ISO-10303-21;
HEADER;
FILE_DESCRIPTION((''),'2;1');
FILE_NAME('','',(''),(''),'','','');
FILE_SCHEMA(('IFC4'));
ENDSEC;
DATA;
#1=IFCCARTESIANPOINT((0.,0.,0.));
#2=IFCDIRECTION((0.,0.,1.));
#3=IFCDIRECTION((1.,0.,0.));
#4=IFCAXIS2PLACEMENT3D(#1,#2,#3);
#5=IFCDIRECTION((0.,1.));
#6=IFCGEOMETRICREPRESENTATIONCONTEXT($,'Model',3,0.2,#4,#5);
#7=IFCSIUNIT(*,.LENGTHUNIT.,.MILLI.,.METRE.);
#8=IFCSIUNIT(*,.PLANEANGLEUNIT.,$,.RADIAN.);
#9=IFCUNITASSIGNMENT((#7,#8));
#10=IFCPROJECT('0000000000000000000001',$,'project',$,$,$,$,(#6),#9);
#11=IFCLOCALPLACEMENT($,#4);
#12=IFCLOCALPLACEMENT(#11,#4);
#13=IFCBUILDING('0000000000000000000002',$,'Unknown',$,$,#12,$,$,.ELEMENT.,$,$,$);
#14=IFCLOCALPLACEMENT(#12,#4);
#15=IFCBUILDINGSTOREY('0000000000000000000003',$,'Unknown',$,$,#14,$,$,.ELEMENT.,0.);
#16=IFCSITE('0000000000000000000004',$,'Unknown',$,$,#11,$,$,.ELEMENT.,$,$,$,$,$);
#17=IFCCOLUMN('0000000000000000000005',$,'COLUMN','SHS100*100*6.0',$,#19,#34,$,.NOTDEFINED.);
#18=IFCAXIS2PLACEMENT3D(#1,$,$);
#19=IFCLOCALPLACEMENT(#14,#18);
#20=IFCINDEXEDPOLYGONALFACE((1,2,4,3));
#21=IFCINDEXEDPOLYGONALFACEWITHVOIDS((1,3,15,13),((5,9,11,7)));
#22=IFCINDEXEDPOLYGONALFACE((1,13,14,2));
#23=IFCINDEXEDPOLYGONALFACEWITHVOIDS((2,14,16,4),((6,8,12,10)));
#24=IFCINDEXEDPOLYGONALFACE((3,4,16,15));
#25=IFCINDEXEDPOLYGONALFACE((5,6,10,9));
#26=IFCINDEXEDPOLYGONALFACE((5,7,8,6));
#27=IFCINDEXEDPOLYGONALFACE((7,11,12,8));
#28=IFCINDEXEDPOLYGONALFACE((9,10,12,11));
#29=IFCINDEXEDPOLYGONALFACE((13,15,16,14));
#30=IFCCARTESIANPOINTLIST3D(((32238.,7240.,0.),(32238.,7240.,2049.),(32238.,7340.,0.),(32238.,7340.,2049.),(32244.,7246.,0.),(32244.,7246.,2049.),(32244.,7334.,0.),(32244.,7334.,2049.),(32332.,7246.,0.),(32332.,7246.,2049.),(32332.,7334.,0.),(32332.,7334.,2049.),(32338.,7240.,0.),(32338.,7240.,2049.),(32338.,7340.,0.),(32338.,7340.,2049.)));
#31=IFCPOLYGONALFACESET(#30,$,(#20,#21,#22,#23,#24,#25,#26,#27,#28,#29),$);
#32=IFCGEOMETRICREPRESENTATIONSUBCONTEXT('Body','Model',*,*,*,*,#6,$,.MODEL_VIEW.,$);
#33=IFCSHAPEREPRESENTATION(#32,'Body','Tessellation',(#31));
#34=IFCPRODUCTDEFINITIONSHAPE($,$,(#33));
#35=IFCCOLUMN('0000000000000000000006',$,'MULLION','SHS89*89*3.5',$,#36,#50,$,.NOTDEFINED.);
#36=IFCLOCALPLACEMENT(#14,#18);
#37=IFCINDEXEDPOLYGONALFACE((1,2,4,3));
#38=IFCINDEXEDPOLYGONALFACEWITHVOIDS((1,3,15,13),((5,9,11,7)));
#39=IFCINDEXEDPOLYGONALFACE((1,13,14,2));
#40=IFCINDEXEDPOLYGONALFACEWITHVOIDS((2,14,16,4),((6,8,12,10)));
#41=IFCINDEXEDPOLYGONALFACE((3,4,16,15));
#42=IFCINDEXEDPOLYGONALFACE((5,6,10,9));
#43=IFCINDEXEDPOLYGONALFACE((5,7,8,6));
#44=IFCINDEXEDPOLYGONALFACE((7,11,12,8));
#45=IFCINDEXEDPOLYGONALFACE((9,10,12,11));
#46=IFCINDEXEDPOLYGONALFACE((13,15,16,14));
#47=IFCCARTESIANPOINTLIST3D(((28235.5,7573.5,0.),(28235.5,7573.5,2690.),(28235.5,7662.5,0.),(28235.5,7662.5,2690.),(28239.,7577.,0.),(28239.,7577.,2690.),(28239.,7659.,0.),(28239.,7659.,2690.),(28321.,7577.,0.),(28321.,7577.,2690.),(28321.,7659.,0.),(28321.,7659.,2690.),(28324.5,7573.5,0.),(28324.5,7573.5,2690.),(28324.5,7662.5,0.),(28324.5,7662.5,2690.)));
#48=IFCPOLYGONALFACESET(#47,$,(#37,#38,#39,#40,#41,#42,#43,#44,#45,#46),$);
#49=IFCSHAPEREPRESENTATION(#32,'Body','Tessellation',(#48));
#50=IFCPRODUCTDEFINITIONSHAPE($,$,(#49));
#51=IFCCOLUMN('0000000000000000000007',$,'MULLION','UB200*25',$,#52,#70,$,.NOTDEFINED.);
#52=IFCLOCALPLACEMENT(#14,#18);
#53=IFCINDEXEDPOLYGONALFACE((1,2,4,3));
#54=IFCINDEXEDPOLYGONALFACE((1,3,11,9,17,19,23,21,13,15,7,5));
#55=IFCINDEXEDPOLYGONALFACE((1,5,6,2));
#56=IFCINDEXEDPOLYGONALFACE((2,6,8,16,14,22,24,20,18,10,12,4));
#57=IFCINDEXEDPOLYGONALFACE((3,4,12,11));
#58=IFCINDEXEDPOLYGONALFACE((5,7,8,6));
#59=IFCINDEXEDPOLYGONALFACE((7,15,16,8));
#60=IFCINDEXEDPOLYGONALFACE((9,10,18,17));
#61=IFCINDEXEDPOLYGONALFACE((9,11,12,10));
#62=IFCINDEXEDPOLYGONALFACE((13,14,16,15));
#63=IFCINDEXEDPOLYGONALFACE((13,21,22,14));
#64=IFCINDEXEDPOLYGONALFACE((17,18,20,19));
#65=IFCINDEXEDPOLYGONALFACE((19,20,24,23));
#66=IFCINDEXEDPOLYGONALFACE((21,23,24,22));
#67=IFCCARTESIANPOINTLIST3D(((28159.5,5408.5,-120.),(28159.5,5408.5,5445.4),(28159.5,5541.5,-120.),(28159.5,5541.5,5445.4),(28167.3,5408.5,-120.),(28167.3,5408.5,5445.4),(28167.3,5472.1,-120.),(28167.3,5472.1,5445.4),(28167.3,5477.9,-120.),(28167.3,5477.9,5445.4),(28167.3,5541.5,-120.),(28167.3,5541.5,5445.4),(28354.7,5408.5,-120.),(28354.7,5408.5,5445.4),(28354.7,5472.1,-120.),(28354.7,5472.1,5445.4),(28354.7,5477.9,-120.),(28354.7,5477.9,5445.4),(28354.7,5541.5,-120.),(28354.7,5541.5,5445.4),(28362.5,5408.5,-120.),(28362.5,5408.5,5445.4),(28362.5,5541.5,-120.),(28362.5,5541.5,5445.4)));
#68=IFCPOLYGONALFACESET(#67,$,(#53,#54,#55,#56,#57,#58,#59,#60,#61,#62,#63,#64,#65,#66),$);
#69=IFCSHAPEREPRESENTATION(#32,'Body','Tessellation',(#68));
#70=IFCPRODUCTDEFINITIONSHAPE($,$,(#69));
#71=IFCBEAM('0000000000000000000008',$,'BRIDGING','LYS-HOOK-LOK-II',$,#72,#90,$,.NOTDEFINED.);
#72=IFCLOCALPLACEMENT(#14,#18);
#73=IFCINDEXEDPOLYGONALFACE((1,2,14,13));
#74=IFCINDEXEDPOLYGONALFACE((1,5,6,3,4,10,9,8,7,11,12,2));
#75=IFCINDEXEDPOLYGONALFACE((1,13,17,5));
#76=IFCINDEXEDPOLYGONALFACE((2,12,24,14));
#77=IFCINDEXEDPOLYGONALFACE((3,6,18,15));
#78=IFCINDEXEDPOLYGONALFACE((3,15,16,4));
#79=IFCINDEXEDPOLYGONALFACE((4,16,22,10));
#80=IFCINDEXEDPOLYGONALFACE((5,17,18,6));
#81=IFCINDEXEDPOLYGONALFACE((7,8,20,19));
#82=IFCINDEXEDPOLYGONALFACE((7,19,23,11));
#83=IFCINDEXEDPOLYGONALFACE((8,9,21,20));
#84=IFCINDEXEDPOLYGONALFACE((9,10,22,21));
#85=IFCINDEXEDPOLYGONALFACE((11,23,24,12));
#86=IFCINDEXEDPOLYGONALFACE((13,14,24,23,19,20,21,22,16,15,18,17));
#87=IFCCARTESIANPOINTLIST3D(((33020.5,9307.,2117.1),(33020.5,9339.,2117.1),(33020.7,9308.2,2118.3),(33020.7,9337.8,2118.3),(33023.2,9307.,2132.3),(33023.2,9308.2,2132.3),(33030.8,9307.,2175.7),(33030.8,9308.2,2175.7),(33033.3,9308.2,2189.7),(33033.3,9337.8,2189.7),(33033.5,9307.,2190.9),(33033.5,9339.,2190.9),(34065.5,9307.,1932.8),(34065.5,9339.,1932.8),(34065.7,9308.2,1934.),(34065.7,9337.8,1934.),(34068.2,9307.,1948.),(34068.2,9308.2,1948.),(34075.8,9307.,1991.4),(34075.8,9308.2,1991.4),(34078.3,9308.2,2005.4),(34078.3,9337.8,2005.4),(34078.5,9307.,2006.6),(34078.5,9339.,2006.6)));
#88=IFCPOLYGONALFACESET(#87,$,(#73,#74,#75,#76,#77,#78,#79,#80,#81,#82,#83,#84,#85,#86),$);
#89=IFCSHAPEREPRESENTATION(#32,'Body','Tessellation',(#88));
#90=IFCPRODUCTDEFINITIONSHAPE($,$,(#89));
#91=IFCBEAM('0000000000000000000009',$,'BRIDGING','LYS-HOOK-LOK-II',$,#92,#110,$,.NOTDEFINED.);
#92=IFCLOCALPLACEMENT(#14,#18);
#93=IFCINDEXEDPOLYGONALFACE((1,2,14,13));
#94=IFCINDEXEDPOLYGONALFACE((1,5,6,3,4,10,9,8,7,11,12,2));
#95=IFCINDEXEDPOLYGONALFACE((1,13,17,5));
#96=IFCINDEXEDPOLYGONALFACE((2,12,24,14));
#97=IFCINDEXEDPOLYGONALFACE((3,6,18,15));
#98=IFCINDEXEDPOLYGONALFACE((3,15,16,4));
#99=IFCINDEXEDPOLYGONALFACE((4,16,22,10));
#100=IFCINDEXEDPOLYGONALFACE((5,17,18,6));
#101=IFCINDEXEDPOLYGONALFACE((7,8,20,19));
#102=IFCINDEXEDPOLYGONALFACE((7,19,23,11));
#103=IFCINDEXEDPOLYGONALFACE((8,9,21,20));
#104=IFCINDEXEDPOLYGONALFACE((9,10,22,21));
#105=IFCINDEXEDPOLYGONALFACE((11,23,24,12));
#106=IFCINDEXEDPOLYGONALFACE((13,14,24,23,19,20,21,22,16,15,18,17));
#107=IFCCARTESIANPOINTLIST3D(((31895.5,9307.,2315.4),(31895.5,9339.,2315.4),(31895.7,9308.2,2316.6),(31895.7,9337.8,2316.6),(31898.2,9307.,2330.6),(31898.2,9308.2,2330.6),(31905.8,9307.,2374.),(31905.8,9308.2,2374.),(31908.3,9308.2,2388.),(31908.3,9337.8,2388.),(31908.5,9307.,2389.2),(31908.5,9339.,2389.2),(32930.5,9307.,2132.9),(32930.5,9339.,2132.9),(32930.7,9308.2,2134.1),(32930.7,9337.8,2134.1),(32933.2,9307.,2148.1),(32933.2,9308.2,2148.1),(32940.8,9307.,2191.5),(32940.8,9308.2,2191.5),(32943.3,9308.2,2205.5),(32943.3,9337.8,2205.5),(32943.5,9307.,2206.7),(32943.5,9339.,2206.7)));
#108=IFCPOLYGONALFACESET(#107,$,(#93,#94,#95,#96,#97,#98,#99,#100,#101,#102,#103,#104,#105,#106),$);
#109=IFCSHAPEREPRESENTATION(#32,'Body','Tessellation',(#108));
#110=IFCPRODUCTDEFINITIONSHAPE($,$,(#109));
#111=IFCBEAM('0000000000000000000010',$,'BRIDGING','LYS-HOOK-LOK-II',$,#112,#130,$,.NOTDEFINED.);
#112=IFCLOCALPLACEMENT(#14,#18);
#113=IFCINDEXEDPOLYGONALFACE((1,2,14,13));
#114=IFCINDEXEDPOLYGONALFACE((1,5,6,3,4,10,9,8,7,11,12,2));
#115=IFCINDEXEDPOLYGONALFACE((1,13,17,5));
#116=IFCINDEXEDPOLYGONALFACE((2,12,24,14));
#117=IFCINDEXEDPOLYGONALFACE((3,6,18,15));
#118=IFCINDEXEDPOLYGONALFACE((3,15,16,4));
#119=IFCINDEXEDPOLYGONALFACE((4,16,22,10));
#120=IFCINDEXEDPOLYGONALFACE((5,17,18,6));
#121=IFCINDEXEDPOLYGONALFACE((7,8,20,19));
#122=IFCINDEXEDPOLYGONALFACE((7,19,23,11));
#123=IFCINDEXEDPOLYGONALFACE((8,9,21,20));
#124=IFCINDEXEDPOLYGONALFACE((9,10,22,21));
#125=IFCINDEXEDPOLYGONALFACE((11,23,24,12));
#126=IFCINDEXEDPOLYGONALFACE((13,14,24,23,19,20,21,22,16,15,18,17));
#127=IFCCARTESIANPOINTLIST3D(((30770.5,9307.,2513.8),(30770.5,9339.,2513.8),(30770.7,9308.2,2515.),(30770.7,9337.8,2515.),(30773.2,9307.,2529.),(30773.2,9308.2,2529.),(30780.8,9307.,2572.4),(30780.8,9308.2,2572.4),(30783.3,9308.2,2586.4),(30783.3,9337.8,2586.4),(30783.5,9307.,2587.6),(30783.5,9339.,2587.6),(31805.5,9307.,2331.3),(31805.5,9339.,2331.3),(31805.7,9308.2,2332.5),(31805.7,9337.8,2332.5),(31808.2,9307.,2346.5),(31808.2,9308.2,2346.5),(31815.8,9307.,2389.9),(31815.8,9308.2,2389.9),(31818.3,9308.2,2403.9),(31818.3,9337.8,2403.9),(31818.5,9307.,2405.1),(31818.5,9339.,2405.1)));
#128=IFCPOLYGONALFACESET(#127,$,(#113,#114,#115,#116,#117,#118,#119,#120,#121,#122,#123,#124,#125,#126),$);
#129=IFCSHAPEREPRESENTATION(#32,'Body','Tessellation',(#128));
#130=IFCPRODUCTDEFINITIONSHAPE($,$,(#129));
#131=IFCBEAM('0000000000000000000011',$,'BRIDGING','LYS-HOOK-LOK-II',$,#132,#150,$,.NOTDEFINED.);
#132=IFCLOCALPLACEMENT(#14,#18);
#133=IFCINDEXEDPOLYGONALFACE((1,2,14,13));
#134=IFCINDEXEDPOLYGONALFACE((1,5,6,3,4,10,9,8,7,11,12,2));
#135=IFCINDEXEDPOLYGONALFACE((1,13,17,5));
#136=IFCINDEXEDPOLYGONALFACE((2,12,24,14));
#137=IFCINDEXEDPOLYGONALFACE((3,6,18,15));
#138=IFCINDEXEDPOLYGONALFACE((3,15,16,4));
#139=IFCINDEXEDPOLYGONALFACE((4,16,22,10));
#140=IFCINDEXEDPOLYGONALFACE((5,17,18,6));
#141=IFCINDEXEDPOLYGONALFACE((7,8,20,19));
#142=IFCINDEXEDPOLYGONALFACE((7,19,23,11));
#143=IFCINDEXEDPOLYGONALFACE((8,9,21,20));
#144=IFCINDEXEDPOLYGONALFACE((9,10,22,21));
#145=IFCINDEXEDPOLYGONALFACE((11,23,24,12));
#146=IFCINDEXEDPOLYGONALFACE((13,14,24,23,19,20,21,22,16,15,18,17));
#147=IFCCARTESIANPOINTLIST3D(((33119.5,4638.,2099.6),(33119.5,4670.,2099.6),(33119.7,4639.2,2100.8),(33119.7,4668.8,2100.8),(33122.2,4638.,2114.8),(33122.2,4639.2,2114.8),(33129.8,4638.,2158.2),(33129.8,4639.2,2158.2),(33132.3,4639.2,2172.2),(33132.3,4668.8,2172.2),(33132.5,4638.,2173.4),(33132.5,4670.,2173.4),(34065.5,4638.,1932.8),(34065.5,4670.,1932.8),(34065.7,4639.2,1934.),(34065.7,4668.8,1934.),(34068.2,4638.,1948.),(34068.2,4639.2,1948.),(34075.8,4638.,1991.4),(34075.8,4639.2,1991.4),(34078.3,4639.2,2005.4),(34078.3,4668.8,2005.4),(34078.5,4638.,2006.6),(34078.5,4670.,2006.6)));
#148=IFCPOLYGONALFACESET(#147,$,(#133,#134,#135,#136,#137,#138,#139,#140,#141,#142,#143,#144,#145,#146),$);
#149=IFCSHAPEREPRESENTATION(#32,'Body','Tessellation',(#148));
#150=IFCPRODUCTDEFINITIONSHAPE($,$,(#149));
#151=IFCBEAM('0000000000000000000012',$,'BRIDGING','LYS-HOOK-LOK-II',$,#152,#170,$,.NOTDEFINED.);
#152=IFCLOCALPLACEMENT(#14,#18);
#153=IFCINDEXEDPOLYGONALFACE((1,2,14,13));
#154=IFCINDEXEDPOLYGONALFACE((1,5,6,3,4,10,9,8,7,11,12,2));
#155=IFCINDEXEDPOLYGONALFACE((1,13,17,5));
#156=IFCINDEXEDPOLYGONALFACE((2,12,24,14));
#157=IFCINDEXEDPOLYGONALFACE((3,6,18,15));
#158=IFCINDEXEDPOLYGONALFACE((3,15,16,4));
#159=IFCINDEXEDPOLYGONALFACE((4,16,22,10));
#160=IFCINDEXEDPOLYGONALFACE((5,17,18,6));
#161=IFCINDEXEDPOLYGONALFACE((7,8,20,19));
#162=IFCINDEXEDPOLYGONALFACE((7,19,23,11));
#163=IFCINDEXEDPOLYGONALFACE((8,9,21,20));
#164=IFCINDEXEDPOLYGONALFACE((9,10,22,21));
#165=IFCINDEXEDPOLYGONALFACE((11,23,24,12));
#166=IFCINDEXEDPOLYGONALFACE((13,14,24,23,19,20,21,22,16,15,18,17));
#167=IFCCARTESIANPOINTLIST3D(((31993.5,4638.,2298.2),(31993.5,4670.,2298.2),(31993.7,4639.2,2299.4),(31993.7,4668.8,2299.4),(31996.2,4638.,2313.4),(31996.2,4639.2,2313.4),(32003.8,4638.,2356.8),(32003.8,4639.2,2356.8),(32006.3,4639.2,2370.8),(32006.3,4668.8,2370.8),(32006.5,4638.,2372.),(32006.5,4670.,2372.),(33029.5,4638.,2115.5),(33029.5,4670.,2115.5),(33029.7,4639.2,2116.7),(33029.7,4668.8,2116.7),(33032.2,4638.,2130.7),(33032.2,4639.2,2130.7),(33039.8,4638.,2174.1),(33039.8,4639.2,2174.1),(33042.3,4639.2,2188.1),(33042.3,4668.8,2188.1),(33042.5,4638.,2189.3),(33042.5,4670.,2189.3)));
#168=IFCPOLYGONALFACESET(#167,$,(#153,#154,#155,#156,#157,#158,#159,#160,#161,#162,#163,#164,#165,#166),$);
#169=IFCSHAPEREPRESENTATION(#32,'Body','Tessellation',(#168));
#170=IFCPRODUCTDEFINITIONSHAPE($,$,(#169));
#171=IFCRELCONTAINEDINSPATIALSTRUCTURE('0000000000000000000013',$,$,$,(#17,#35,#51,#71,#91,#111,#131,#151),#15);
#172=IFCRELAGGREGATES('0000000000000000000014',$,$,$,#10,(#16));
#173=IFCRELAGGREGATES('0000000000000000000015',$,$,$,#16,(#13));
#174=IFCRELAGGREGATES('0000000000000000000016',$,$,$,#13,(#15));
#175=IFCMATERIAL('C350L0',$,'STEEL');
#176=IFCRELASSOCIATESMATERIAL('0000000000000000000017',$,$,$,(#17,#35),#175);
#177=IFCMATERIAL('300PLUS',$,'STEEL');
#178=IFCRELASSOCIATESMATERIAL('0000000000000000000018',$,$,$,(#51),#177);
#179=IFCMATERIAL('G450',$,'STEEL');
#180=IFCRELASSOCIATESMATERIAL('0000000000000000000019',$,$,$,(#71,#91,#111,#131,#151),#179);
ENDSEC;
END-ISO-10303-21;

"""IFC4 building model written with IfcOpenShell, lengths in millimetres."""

from ifc_helpers import new_model, si_unit, direction, frame, origin_with_axes, place, context, subcontext, project, spatial, line, indexed_curve, outline, extrude, material, element, save


model = new_model("IFC4")

# Units and contexts
model_context = context("Model", 3, precision=0.2, world=origin_with_axes(), true_north=direction((0.0, 1.0)))
body_context = subcontext(model_context, "Body", "Model", "MODEL_VIEW")
ifc_project = project(units=[si_unit("LENGTHUNIT", "METRE", prefix="MILLI"), si_unit("PLANEANGLEUNIT", "RADIAN")], contexts=[model_context])

# Site, building, storey
site_placement = place(None, origin_with_axes())
site = spatial("IfcSite", under=ifc_project, at=site_placement, Name="Unknown", CompositionType="ELEMENT")
building_placement = place(site_placement, origin_with_axes())
building = spatial("IfcBuilding", under=site, at=building_placement, Name="Unknown", CompositionType="ELEMENT")
storey_placement = place(building_placement, origin_with_axes())
storey = spatial("IfcBuildingStorey", under=building, at=storey_placement, Name="Unknown", CompositionType="ELEMENT", Elevation=0.0)

# Columns
ifc_material_1 = material(Name="C350L0", Category="STEEL")
column_1_placement = place(storey_placement, frame((32288.0, 7290.0, 0.0), z_axis=(-1.0, 0.0, 0.0), x_axis=(0.0, 0.0, 1.0)))
element("IfcColumn", 1, at=column_1_placement, inside=storey, material=ifc_material_1, Name="COLUMN", Description="SHS100*100*6.0", PredefinedType="NOTDEFINED", context=body_context, shape_type="SolidModel", body=[
    extrude(outline(indexed_curve([(-50.0, -50.0), (50.0, -50.0), (50.0, 50.0), (-50.0, 50.0)], segments=[line(1, 2, 3, 4, 1)]), holes=[indexed_curve([(-44.0, -44.0), (-44.0, 44.0), (44.0, 44.0), (44.0, -44.0)], segments=[line(1, 2, 3, 4, 1)])]), frame((0.0, 0.0, 0.0), z_axis=(-1.0, 0.0, 0.0), x_axis=(0.0, 0.0, 1.0)), (0.0, 0.0, -1.0), 2049.0),
])
column_2_placement = place(storey_placement, frame((28280.0, 7618.0, 0.0), z_axis=(-1.0, 0.0, 0.0), x_axis=(0.0, 0.0, 1.0)))
element("IfcColumn", 2, at=column_2_placement, inside=storey, material=ifc_material_1, Name="MULLION", Description="SHS89*89*3.5", PredefinedType="NOTDEFINED", context=body_context, shape_type="SolidModel", body=[
    extrude(outline(indexed_curve([(-44.5, -44.5), (44.5, -44.5), (44.5, 44.5), (-44.5, 44.5)], segments=[line(1, 2, 3, 4, 1)]), holes=[indexed_curve([(-41.0, -41.0), (-41.0, 41.0), (41.0, 41.0), (41.0, -41.0)], segments=[line(1, 2, 3, 4, 1)])]), frame((0.0, 0.0, 0.0), z_axis=(-1.0, 0.0, 0.0), x_axis=(0.0, 0.0, 1.0)), (0.0, 0.0, -1.0), 2690.0),
])
ifc_material_2 = material(Name="300PLUS", Category="STEEL")
column_3_placement = place(storey_placement, frame((28261.0, 5475.0, -120.0), z_axis=(0.0, -1.0, 0.0), x_axis=(0.0, 0.0, 1.0)))
element("IfcColumn", 3, at=column_3_placement, inside=storey, material=ifc_material_2, Name="MULLION", Description="UB200*25", PredefinedType="NOTDEFINED", context=body_context, shape_type="SolidModel", body=[
    extrude(outline(indexed_curve([(-66.5, -101.5), (66.5, -101.5), (66.5, -93.7), (2.9, -93.7), (2.9, 93.7), (66.5, 93.7), (66.5, 101.5), (-66.5, 101.5), (-66.5, 93.7), (-2.9, 93.7), (-2.9, -93.7), (-66.5, -93.7)], segments=[line(1, 2, 3, 4, 5, 6, 7, 8, 9, 10, 11, 12, 1)])), frame((0.0, 0.0, 0.0), z_axis=(-1.0, 0.0, 0.0), x_axis=(0.0, 0.0, 1.0)), (0.0, 0.0, -1.0), 5565.4),
])

# Beams
ifc_material_3 = material(Name="G450", Category="STEEL")
beam_1_placement = place(storey_placement, frame((33027.0, 9323.0, 2154.0), z_axis=(0.0, -1.0, 0.0), x_axis=(0.984802, 0.0, -0.173683)))
element("IfcBeam", 4, at=beam_1_placement, inside=storey, material=ifc_material_3, Name="BRIDGING", Description="LYS-HOOK-LOK-II", PredefinedType="NOTDEFINED", context=body_context, shape_type="SolidModel", body=[
    extrude(outline(indexed_curve([(16.0, -37.5), (16.0, -22.0), (14.8, -22.0), (14.8, -36.3), (-14.8, -36.3), (-14.8, 36.3), (14.8, 36.3), (14.8, 22.0), (16.0, 22.0), (16.0, 37.5), (-16.0, 37.5), (-16.0, -37.5)], segments=[line(1, 2, 3, 4, 5, 6, 7, 8, 9, 10, 11, 12, 1)])), frame((0.0, 0.0, 0.0), z_axis=(-1.0, 0.0, 0.0), x_axis=(0.0, 0.0, 1.0)), (0.0, 0.0, -1.0), 1061.1),
])
for number, where, z_axis, x_axis, name in (
    (5, (31902.0, 9323.0, 2352.3), (0.0, -1.0, 0.0), (0.984807, 0.0, -0.17365), "BRIDGING"),
    (6, (30777.0, 9323.0, 2550.7), (0.0, -1.0, 0.0), (0.984807, 0.0, -0.17365), "BRIDGING"),
):
    element("IfcBeam", number, at=place(storey_placement, frame(where, z_axis=z_axis, x_axis=x_axis)), inside=storey, material=ifc_material_3, Name=name, Description="LYS-HOOK-LOK-II", PredefinedType="NOTDEFINED", context=body_context, shape_type="SolidModel", body=[
        extrude(outline(indexed_curve([(16.0, -37.5), (16.0, -22.0), (14.8, -22.0), (14.8, -36.3), (-14.8, -36.3), (-14.8, 36.3), (14.8, 36.3), (14.8, 22.0), (16.0, 22.0), (16.0, 37.5), (-16.0, 37.5), (-16.0, -37.5)], segments=[line(1, 2, 3, 4, 5, 6, 7, 8, 9, 10, 11, 12, 1)])), frame((0.0, 0.0, 0.0), z_axis=(-1.0, 0.0, 0.0), x_axis=(0.0, 0.0, 1.0)), (0.0, 0.0, -1.0), 1051.0),
    ])
beam_2_placement = place(storey_placement, frame((33126.0, 4654.0, 2136.5), z_axis=(0.0, -1.0, 0.0), x_axis=(0.984809, 0.0, -0.173643)))
element("IfcBeam", 7, at=beam_2_placement, inside=storey, material=ifc_material_3, Name="BRIDGING", Description="LYS-HOOK-LOK-II", PredefinedType="NOTDEFINED", context=body_context, shape_type="SolidModel", body=[
    extrude(outline(indexed_curve([(16.0, -37.5), (16.0, -22.0), (14.8, -22.0), (14.8, -36.3), (-14.8, -36.3), (-14.8, 36.3), (14.8, 36.3), (14.8, 22.0), (16.0, 22.0), (16.0, 37.5), (-16.0, 37.5), (-16.0, -37.5)], segments=[line(1, 2, 3, 4, 5, 6, 7, 8, 9, 10, 11, 12, 1)])), frame((0.0, 0.0, 0.0), z_axis=(-1.0, 0.0, 0.0), x_axis=(0.0, 0.0, 1.0)), (0.0, 0.0, -1.0), 960.6),
])
beam_3_placement = place(storey_placement, frame((32000.0, 4654.0, 2335.1), z_axis=(0.0, -1.0, 0.0), x_axis=(0.984804, 0.0, -0.173671)))
element("IfcBeam", 8, at=beam_3_placement, inside=storey, material=ifc_material_3, Name="BRIDGING", Description="LYS-HOOK-LOK-II", PredefinedType="NOTDEFINED", context=body_context, shape_type="SolidModel", body=[
    extrude(outline(indexed_curve([(16.0, -37.5), (16.0, -22.0), (14.8, -22.0), (14.8, -36.3), (-14.8, -36.3), (-14.8, 36.3), (14.8, 36.3), (14.8, 22.0), (16.0, 22.0), (16.0, 37.5), (-16.0, 37.5), (-16.0, -37.5)], segments=[line(1, 2, 3, 4, 5, 6, 7, 8, 9, 10, 11, 12, 1)])), frame((0.0, 0.0, 0.0), z_axis=(-1.0, 0.0, 0.0), x_axis=(0.0, 0.0, 1.0)), (0.0, 0.0, -1.0), 1052.0),
])

save(model, "model.ifc")
